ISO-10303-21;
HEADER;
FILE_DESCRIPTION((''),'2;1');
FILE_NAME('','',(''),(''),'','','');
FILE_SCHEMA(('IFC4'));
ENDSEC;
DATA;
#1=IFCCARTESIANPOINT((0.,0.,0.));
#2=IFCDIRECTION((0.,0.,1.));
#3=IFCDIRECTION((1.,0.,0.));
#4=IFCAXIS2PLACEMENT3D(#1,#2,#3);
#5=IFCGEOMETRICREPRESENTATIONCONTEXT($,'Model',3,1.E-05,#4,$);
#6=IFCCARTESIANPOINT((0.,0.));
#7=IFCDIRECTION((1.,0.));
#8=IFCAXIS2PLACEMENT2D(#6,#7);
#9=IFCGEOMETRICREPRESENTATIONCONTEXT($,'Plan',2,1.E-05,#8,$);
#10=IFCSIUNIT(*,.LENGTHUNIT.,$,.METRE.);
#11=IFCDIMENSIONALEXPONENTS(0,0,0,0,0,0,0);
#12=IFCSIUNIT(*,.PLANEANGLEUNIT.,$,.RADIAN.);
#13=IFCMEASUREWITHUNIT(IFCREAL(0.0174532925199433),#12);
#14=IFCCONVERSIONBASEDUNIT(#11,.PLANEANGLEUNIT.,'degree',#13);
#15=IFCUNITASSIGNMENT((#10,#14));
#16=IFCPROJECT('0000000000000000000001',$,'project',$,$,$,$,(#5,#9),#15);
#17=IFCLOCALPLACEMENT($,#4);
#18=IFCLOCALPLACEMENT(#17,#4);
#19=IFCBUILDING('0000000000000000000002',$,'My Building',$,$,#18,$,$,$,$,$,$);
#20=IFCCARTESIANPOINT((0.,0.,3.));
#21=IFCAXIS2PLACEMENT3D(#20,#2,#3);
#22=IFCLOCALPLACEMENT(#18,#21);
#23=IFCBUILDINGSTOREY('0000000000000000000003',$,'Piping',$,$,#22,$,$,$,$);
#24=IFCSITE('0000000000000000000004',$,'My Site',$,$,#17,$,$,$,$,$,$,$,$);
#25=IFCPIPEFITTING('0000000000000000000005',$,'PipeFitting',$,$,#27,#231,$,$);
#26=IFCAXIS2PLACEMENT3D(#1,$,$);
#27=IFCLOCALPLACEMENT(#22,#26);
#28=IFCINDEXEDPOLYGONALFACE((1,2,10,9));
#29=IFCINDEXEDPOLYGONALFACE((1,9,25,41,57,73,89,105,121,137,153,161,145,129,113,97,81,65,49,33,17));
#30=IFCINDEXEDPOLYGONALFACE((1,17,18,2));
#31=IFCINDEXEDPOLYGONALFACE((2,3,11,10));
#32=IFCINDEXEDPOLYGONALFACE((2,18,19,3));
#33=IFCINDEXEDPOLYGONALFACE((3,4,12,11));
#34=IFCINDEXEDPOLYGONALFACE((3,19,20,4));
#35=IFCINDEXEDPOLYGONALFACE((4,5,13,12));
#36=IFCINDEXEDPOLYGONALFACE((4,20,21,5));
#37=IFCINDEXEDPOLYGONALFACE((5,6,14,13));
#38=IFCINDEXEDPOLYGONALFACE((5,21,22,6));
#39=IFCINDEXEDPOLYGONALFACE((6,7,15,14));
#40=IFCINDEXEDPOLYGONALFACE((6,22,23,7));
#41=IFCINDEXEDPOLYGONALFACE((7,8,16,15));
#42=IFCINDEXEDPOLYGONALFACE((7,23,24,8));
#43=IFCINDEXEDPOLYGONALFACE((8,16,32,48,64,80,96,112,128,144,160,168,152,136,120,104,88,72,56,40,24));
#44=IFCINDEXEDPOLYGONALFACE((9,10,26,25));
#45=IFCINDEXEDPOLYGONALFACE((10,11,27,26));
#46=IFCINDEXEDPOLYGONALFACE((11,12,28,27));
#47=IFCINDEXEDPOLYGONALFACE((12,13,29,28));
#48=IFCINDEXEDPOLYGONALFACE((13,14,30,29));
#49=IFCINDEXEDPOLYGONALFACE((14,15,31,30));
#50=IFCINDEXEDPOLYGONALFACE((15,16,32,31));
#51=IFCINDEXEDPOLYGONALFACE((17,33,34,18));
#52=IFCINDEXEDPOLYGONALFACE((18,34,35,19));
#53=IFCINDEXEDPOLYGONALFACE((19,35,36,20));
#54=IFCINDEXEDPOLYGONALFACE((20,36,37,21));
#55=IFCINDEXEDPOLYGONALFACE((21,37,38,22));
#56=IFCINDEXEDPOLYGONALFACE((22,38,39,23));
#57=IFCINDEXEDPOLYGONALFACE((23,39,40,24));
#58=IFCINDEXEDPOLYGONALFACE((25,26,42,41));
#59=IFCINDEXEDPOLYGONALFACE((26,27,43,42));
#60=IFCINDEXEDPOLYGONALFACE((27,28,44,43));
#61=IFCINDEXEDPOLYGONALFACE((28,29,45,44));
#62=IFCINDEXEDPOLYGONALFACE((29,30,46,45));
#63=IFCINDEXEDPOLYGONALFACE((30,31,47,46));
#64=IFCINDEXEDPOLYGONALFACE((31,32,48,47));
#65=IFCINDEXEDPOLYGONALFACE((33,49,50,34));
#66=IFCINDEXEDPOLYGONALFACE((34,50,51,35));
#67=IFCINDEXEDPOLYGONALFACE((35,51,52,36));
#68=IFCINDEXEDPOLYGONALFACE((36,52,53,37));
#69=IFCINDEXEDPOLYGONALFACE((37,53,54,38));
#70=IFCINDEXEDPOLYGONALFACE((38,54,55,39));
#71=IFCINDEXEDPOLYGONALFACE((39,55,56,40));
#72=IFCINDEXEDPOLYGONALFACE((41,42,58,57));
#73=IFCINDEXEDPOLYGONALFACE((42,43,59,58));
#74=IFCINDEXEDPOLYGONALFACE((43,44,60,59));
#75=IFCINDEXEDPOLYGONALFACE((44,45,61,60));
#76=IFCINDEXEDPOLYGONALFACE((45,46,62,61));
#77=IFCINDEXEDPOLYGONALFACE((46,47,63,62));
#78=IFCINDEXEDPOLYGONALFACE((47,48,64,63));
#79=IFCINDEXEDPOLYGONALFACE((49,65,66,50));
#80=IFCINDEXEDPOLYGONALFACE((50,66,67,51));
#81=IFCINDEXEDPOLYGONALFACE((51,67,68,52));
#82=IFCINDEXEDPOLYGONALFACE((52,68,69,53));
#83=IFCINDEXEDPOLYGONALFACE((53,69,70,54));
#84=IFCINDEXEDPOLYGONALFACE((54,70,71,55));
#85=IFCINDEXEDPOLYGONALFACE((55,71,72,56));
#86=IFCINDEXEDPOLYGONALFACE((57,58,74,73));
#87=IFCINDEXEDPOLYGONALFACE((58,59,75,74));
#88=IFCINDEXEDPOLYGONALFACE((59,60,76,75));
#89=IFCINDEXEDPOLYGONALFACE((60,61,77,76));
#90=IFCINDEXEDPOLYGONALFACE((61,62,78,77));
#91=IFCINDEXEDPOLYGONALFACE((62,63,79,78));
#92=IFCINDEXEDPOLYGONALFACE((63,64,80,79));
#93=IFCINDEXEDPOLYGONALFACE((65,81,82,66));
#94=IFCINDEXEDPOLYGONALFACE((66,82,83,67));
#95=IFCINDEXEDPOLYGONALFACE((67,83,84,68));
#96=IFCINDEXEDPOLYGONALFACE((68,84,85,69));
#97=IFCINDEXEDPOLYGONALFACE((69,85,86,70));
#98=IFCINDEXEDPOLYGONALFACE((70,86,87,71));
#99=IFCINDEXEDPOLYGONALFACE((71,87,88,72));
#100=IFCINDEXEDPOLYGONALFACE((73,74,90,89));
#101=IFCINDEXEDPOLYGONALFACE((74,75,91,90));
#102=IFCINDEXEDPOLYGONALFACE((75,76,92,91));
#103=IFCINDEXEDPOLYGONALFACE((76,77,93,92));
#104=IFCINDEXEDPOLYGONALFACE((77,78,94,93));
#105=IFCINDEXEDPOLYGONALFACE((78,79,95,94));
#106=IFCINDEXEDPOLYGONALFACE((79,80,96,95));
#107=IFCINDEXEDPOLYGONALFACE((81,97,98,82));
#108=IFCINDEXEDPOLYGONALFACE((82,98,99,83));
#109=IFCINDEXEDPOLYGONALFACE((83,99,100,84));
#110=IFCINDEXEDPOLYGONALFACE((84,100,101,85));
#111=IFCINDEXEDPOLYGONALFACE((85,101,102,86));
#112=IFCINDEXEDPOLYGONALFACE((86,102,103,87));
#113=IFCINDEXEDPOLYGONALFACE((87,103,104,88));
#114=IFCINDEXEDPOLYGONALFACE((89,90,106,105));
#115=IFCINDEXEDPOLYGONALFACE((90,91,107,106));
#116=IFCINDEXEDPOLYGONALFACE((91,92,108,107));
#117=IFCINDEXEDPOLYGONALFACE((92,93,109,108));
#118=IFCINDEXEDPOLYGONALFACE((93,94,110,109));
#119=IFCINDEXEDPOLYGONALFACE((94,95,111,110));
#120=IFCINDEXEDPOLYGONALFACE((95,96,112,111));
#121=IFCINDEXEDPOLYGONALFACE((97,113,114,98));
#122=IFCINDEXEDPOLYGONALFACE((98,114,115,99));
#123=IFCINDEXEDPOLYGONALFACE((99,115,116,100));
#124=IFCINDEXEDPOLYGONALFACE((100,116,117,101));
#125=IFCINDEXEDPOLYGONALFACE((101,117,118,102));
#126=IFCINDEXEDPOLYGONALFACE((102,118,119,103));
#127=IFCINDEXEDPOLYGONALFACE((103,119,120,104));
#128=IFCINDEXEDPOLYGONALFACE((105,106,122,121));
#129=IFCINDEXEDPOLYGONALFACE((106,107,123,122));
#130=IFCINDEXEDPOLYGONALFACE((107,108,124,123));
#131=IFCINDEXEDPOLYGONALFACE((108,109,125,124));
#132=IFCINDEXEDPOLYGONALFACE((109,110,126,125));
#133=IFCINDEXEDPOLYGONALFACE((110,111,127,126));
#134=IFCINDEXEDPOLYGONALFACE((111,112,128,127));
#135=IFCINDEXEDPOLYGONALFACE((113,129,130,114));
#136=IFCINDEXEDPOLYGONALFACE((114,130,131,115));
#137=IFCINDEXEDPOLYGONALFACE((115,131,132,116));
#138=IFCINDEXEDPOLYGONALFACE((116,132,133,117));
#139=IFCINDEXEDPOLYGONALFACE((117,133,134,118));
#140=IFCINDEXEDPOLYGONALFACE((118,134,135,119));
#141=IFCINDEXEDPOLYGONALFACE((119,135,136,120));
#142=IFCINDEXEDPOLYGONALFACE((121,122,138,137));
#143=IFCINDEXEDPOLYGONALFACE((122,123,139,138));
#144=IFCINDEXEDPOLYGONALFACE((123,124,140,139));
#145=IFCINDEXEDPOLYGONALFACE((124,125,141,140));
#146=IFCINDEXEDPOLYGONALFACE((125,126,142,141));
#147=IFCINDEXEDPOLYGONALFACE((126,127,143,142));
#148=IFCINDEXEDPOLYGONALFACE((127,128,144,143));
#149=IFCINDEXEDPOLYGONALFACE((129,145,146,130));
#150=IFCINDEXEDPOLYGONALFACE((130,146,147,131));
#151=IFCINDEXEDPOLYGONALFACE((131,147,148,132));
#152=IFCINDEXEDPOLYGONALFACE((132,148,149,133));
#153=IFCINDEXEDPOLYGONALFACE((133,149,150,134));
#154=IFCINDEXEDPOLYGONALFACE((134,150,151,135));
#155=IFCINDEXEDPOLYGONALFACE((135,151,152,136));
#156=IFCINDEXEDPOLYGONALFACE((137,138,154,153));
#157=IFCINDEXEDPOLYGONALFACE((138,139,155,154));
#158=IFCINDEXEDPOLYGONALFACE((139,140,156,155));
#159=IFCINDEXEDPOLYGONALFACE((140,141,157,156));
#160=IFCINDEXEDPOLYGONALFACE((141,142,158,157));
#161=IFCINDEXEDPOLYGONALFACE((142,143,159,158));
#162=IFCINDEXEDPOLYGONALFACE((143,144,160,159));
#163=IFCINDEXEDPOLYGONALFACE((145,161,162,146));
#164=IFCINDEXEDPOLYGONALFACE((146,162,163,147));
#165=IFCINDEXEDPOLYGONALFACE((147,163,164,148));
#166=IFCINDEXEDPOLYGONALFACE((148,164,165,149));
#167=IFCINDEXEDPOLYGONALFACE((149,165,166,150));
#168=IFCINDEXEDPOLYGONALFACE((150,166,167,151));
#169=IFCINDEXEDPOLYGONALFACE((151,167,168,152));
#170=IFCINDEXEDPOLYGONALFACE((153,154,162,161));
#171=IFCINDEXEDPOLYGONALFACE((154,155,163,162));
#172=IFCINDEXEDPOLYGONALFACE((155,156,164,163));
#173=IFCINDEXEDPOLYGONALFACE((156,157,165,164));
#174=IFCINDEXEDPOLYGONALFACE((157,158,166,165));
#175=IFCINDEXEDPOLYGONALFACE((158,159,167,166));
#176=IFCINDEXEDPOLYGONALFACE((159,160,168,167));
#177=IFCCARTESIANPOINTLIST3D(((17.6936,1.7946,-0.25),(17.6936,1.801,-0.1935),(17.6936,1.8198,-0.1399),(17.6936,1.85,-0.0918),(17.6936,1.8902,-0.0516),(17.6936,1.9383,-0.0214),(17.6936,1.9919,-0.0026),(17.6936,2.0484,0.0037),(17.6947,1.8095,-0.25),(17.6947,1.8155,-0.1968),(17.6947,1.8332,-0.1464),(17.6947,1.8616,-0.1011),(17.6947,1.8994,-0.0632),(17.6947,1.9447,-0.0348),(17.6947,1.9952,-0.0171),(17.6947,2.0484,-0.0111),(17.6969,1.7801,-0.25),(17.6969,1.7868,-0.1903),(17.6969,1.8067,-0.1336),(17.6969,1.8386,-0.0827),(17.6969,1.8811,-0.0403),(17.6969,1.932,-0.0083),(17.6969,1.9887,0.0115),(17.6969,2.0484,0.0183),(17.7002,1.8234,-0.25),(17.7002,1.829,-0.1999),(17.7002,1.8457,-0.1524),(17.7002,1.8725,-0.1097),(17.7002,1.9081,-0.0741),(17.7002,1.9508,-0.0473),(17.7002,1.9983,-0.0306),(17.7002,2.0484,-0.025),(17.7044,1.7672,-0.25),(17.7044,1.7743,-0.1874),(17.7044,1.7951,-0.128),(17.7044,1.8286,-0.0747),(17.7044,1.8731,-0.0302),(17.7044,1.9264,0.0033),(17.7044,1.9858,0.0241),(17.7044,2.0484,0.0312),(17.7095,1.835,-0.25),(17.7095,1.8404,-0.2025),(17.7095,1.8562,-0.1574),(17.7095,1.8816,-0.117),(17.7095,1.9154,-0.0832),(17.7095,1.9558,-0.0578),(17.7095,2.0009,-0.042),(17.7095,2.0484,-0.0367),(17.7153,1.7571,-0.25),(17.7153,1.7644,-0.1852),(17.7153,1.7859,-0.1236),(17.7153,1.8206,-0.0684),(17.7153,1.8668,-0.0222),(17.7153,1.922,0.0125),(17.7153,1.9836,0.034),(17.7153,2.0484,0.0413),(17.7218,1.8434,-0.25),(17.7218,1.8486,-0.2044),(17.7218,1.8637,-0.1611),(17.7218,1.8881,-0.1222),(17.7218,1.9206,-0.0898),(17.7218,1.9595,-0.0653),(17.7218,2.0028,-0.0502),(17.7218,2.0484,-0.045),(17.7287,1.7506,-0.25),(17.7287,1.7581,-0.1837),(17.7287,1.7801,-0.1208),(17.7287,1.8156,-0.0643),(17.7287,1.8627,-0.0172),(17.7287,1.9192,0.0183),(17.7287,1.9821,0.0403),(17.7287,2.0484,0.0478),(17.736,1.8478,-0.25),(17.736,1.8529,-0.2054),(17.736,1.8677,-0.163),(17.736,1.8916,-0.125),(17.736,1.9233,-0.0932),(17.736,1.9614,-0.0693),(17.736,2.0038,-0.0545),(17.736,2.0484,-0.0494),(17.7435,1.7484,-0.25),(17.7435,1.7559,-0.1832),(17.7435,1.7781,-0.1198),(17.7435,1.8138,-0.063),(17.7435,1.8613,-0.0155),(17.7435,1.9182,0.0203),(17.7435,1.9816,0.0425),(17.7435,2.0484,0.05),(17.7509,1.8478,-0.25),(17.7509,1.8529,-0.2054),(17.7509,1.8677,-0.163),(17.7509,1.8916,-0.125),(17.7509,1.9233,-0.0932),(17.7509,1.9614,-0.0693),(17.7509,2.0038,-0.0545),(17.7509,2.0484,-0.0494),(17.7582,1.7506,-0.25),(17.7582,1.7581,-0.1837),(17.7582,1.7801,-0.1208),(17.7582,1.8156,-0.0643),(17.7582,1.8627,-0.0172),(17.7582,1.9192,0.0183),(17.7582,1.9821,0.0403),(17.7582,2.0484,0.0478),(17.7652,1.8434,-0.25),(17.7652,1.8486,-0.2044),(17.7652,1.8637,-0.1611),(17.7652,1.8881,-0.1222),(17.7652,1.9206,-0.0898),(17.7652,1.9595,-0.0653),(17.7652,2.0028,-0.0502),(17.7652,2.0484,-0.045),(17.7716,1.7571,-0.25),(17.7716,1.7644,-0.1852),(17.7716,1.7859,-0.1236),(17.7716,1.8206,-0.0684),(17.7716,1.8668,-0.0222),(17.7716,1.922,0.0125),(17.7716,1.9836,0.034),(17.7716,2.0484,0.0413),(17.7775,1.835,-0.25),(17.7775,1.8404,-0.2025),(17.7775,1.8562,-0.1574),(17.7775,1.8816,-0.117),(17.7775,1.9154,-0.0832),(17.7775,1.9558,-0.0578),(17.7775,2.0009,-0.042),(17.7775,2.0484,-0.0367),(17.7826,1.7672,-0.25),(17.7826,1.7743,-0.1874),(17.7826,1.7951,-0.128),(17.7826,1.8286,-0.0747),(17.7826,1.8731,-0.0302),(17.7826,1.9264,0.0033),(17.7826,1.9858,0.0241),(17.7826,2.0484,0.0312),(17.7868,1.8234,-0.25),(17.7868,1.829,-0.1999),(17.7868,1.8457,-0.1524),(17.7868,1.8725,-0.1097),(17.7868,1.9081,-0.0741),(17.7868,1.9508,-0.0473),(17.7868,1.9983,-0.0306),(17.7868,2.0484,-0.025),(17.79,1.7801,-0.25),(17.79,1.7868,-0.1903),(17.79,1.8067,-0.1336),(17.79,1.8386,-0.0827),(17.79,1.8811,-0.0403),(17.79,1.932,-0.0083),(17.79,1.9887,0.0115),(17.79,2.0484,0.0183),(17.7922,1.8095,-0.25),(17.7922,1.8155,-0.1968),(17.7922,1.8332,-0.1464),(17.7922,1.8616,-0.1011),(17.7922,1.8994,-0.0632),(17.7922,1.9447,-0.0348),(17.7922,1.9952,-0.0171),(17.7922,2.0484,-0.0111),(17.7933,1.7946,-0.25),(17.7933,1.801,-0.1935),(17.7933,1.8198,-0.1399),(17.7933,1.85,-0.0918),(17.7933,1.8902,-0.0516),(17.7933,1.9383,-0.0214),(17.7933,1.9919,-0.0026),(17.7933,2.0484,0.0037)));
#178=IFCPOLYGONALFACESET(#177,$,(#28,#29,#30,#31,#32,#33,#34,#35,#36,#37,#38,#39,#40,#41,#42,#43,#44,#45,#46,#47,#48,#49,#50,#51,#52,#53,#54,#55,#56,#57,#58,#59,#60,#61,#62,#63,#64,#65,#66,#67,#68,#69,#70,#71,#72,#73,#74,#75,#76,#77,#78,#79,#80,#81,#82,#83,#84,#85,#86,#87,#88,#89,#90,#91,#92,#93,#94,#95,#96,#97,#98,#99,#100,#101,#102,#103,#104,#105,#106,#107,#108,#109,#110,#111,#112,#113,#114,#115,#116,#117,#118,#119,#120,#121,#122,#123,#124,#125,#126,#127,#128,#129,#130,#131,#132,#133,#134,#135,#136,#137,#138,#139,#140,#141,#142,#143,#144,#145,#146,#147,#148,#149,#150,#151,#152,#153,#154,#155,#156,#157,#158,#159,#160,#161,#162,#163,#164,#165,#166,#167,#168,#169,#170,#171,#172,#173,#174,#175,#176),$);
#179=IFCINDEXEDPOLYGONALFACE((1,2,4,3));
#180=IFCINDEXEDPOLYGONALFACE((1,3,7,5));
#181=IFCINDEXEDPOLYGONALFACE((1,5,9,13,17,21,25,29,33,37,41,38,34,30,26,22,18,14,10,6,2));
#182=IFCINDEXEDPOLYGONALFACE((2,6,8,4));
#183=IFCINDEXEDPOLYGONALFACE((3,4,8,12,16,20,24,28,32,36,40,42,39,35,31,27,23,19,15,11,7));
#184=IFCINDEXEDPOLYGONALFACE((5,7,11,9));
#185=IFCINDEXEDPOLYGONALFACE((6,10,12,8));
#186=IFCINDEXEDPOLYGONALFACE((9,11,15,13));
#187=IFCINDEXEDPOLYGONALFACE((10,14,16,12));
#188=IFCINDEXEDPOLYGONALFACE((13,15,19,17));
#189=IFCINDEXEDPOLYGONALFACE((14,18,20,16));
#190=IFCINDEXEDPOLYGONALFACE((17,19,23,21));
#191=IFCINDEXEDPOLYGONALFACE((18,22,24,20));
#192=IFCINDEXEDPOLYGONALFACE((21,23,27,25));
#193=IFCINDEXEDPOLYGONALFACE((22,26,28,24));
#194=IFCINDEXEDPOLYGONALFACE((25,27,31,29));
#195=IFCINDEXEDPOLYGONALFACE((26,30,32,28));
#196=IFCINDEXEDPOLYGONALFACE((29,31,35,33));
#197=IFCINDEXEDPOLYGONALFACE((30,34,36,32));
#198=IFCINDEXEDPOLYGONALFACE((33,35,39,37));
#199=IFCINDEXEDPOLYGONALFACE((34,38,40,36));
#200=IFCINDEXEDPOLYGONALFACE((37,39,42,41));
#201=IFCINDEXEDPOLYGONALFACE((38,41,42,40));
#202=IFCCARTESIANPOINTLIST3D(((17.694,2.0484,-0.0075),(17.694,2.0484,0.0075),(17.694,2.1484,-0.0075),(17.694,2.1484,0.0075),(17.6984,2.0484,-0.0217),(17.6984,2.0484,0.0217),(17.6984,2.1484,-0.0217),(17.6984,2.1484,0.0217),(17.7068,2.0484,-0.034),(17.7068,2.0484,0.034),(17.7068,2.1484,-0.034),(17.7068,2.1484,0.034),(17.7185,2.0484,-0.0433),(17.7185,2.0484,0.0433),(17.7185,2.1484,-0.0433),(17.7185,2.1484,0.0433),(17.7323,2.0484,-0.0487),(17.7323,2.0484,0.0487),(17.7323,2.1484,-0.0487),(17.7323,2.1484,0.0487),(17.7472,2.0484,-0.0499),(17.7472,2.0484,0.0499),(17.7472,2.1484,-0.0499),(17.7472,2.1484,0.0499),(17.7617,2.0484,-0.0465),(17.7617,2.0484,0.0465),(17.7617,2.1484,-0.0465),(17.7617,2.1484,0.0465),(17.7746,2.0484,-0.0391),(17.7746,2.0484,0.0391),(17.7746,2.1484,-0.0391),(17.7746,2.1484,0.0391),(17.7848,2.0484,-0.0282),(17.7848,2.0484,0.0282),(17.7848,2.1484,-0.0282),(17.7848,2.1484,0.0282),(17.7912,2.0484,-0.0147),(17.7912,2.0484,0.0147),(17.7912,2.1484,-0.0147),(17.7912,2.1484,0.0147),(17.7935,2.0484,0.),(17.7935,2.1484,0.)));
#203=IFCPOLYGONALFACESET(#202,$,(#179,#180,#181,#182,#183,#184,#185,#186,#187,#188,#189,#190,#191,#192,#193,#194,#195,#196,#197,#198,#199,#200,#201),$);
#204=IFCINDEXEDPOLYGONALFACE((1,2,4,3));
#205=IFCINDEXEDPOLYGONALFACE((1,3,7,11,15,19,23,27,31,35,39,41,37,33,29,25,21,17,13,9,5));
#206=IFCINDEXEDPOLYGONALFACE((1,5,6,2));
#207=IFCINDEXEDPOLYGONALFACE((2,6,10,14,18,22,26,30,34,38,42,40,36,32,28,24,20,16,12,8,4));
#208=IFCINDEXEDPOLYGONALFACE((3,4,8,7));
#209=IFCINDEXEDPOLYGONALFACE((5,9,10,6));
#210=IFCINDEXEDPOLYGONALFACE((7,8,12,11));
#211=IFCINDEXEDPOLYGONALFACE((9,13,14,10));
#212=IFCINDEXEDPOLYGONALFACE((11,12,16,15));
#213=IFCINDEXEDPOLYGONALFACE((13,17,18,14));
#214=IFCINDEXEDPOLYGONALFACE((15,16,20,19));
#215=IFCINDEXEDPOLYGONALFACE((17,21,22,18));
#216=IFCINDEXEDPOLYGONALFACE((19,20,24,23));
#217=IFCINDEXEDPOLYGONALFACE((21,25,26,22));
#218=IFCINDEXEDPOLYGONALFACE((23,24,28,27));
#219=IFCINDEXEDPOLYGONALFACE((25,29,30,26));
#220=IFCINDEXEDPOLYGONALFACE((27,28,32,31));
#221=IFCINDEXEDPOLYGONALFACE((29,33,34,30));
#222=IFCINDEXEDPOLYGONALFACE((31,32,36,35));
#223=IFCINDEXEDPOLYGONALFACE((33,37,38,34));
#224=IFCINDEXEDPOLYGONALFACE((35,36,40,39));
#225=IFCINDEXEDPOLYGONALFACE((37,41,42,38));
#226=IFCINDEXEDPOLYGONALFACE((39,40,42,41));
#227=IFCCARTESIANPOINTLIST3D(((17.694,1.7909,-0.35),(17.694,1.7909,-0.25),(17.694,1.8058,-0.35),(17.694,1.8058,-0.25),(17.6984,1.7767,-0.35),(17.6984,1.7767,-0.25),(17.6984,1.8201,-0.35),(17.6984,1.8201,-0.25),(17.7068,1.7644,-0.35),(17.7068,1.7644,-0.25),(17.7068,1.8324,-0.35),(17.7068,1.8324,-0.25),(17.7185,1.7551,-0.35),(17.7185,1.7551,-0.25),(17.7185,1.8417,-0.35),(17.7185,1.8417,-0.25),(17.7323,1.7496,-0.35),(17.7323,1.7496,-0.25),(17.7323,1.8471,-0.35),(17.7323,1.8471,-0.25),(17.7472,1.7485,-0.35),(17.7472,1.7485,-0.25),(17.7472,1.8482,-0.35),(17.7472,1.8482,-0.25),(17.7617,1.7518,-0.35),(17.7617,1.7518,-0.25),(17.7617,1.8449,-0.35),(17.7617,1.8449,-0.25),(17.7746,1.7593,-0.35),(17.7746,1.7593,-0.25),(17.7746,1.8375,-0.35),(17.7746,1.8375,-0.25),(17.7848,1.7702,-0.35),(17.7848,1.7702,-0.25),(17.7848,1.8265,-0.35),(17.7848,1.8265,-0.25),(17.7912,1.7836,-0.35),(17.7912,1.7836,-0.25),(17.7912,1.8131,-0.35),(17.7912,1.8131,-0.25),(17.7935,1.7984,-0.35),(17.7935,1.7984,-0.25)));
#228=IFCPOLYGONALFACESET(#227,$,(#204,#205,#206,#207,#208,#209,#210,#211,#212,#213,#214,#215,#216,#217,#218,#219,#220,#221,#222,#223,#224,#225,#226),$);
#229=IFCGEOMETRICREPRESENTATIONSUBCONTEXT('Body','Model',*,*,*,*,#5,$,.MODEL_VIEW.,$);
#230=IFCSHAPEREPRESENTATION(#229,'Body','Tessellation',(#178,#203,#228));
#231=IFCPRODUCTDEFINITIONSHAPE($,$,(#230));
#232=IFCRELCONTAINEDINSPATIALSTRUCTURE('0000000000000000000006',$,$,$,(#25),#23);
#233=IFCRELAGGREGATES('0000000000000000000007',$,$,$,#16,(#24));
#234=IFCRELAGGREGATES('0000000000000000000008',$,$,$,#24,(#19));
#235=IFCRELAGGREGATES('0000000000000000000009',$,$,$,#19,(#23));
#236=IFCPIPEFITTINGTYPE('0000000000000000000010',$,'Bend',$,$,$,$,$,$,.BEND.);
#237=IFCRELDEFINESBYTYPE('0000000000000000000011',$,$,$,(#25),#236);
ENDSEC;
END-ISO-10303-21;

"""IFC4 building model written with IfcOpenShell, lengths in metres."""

from ifc_helpers import new_model, entity, si_unit, converted_unit, frame, origin_with_axes, origin_2d_with_axis, place, context, subcontext, project, spatial, line, indexed_curve, circle, outline, extrude, source, transform, mapped, type_object, type_shapes, element, save


model = new_model("IFC4")

# Units and contexts
model_context = context("Model", 3, precision=1e-05, world=origin_with_axes())
plan_context = context("Plan", 2, precision=1e-05, world=origin_2d_with_axis())
body_context = subcontext(model_context, "Body", "Model", "MODEL_VIEW")
ifc_project = project(units=[si_unit("LENGTHUNIT", "METRE"), converted_unit("PLANEANGLEUNIT", "degree", entity("IfcReal", 0.0174532925199433), si_unit("PLANEANGLEUNIT", "RADIAN"), dimensions=[0, 0, 0, 0, 0, 0, 0])], contexts=[model_context, plan_context])

# Site, building, storey
site_placement = place(None, origin_with_axes())
site = spatial("IfcSite", under=ifc_project, at=site_placement, Name="My Site")
building_placement = place(site_placement, origin_with_axes())
building = spatial("IfcBuilding", under=site, at=building_placement, Name="My Building")
storey_placement = place(building_placement, frame((0.0, 0.0, 3.0), z_axis=(0.0, 0.0, 1.0), x_axis=(1.0, 0.0, 0.0)))
storey = spatial("IfcBuildingStorey", under=building, at=storey_placement, Name="Piping")

# Pipe fitting, opening
pipe_fitting_type = type_object("IfcPipeFittingType", Name="Bend", PredefinedType="BEND")
shared_shape = source(origin_with_axes(), body_context, "Body", "SolidModel", [
    entity("IfcSweptDiskSolid", entity("IfcIndexedPolyCurve", entity("IfcCartesianPointList3D", [[0.0, 0.0, 0.1], [0.0, -0.0732, 0.2768], [0.0, -0.25, 0.35]]), [entity("IfcArcIndex", [1, 2, 3])]), 0.05),
    extrude(circle(Radius=0.05), origin_with_axes(), (0.0, 0.0, 1.0), 0.1),
    extrude(circle(Radius=0.05), frame((0.0, -0.25, 0.35), z_axis=(0.0, -1.0, 0.0), x_axis=(1.0, 0.0, 0.0)), (0.0, 0.0, 1.0), 0.1),
])
type_shapes(pipe_fitting_type, [shared_shape])
pipe_fitting_1_placement = place(storey_placement, frame((17.7435, 2.1484, 0.0), z_axis=(0.0, -1.0, 0.0), x_axis=(1.0, 0.0, 0.0)))
pipe_fitting_1 = element("IfcPipeFitting", 1, at=pipe_fitting_1_placement, inside=storey, type_object=pipe_fitting_type, Name="PipeFitting", context=body_context, shape_type="MappedRepresentation", body=[
    mapped(shared_shape, transform((0.0, 0.0, 0.0), x_axis=(1.0, 0.0, 0.0), y_axis=(0.0, 1.0, 0.0), z_axis=(0.0, 0.0, 1.0), scale=1.0)),
])
opening_1_placement = place(pipe_fitting_1_placement, frame((-17.7435, -3.0, 2.1484), z_axis=(0.0, 1.0, 0.0), x_axis=(1.0, 0.0, 0.0)))
element("IfcOpeningElement", 2, at=opening_1_placement, cuts=pipe_fitting_1, PredefinedType="OPENING", context=body_context, shape_type="SweptSolid", body=[
    extrude(outline(indexed_curve([(0.0, 0.0), (0.5, 0.0), (0.5, 0.5), (0.0, 0.5)], segments=[line(1, 2, 3, 4, 1)])), origin_with_axes(), (0.0, 0.0, 1.0), 0.5),
])

save(model, "model.ifc")
